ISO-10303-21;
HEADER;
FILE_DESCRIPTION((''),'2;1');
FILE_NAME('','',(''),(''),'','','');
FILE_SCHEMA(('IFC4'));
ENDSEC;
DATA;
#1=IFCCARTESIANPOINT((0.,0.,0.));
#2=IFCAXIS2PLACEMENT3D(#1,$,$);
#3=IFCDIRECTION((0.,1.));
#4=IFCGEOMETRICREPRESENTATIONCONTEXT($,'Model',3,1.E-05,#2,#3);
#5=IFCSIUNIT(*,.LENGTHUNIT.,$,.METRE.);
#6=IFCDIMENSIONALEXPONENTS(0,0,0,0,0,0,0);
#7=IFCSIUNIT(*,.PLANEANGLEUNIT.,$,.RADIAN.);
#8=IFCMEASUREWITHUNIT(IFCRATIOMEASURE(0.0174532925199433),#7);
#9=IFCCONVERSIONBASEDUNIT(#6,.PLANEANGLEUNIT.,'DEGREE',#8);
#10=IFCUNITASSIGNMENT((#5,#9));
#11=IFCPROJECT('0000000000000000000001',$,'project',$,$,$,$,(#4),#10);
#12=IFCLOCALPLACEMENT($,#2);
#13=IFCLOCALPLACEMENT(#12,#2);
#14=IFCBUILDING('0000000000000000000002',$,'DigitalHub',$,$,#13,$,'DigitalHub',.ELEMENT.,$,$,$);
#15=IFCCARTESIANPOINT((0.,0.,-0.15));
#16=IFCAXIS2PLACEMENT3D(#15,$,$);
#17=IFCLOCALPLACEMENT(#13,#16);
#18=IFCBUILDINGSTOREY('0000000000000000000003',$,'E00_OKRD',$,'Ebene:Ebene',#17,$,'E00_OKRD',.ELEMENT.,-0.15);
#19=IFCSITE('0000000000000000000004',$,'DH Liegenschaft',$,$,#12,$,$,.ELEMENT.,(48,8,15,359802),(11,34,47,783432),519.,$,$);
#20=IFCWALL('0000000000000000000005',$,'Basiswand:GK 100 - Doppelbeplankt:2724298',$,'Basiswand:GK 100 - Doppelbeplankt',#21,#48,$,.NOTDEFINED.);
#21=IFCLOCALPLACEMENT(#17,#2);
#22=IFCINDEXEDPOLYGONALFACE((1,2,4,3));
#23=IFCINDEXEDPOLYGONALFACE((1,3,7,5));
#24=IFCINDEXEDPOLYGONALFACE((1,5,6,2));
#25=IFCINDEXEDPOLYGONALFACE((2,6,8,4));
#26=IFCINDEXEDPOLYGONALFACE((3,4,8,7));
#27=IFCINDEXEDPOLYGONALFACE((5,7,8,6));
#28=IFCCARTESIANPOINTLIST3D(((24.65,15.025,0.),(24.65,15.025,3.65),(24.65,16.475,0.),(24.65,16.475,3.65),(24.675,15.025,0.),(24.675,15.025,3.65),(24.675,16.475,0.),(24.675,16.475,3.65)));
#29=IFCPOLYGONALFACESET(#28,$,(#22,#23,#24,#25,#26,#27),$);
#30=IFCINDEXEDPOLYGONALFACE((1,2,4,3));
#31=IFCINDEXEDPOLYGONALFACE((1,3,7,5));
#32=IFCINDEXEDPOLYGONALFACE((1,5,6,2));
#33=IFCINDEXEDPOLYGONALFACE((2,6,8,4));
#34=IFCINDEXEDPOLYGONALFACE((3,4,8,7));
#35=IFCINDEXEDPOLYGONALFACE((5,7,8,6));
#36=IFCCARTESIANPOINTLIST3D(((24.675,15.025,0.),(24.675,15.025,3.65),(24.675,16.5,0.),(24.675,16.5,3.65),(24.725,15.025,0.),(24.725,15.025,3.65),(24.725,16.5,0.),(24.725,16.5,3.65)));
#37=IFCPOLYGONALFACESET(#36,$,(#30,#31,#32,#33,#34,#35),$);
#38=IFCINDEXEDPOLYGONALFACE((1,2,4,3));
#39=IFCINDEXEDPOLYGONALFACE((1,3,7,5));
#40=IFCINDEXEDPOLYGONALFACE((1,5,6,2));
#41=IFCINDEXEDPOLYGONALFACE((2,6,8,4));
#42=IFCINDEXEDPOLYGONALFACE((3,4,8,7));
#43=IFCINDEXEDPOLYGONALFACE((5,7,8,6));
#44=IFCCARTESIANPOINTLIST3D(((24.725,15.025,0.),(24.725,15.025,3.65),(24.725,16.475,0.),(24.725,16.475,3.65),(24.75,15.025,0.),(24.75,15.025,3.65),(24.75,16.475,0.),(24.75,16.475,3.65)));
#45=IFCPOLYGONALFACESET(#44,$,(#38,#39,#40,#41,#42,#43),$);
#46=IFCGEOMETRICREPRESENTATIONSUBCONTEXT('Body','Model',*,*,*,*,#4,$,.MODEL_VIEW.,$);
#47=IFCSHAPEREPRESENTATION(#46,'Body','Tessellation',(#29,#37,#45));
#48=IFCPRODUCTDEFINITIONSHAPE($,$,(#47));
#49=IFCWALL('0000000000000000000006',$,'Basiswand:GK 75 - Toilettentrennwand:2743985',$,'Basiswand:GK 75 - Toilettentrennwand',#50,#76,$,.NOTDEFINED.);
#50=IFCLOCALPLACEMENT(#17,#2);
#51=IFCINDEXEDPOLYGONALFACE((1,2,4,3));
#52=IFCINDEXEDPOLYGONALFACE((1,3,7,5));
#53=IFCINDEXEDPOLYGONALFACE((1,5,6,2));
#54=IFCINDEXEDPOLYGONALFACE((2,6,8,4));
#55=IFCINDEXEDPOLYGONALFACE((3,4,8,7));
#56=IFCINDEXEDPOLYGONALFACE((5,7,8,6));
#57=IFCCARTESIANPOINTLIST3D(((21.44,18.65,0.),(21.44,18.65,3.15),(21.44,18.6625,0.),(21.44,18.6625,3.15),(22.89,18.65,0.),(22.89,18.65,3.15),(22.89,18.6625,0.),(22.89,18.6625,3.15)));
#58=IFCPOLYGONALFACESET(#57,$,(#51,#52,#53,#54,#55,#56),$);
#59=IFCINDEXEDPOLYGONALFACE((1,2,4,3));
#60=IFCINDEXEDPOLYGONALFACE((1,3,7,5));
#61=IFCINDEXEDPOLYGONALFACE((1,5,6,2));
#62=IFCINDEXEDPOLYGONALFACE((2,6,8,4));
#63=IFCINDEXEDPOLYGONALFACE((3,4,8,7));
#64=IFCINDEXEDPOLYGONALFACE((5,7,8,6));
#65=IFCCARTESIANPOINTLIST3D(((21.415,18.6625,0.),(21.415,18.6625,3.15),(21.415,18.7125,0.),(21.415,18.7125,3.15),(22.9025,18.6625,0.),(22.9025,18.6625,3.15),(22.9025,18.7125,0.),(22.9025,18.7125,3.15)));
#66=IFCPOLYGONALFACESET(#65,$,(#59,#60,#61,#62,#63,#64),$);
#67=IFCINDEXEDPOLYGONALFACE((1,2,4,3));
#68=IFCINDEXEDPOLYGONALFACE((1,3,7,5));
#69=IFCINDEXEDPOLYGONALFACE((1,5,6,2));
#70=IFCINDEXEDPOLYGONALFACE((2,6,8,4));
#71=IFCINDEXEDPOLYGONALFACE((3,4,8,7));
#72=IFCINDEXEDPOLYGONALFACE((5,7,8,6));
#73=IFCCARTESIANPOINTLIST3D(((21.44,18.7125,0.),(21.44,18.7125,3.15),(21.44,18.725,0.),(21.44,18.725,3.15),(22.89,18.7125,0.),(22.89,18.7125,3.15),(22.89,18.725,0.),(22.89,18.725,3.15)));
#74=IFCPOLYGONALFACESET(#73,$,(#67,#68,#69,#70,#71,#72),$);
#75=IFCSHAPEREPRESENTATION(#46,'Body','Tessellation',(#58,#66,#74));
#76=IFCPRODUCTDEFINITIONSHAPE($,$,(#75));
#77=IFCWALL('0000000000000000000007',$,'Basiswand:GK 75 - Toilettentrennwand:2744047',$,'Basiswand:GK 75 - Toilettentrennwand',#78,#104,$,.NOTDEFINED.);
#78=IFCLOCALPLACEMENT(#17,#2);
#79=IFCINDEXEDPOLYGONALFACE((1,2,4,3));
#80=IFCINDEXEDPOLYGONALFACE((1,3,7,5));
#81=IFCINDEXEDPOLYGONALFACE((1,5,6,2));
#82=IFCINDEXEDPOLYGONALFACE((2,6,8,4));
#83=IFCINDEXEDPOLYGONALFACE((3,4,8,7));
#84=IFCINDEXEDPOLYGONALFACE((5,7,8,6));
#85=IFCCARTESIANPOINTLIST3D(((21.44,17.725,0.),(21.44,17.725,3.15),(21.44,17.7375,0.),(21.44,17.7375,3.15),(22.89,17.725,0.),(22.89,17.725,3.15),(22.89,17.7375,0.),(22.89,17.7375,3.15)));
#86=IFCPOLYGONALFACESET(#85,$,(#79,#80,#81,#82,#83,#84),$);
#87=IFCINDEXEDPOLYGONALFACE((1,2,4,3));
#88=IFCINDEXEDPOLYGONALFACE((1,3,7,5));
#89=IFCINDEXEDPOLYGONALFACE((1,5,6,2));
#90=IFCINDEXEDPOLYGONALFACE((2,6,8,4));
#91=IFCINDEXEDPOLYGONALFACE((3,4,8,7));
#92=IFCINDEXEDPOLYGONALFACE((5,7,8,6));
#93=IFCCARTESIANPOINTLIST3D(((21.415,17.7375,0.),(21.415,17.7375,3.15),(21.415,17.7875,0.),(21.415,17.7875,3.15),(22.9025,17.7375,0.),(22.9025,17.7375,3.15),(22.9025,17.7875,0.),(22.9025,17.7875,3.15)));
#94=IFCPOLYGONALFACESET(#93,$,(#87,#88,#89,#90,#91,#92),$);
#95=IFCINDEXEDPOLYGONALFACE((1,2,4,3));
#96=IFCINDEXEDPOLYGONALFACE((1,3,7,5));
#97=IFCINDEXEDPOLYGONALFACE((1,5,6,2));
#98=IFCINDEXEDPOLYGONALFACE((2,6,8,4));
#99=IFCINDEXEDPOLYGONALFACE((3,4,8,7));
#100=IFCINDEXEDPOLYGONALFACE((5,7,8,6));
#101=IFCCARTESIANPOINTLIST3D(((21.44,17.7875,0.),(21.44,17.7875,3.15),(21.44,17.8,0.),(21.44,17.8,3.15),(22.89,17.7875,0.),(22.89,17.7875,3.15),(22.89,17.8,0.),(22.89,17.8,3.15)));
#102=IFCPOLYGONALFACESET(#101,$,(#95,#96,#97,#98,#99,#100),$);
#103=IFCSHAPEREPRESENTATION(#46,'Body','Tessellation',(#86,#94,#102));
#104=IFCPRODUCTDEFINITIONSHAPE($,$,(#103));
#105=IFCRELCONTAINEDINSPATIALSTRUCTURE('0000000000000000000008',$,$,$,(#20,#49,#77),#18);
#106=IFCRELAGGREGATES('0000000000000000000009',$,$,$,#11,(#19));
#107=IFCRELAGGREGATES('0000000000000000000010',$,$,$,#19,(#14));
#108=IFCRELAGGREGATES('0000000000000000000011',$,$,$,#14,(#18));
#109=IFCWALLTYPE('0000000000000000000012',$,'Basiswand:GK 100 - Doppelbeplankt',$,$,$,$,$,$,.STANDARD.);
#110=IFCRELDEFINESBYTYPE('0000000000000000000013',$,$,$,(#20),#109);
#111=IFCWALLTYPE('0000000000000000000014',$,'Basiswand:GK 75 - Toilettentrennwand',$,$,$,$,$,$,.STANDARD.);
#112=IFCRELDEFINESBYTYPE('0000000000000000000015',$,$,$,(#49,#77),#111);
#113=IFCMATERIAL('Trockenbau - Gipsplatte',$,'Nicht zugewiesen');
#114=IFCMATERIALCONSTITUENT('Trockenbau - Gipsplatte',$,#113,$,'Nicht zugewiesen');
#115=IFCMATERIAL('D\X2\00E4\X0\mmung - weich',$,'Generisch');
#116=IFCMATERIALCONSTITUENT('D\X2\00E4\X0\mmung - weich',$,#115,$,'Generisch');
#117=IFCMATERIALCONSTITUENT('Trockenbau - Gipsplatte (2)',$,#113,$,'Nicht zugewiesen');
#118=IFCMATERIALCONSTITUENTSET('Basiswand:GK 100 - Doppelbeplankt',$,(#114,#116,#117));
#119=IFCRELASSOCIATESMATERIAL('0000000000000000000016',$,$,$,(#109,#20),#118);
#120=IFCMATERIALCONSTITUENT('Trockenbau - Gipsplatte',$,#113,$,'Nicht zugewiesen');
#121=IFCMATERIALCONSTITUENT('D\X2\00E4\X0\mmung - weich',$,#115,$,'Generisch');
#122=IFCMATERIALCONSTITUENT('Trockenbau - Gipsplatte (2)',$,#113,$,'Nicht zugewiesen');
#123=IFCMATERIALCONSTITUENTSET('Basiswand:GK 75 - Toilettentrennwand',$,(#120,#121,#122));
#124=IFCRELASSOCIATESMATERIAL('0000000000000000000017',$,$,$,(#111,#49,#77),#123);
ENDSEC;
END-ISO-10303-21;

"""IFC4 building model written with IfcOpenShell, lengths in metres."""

from ifc_helpers import new_model, entity, si_unit, converted_unit, direction, frame, origin, place, context, subcontext, project, spatial, indexed_curve, outline, extrude, material, constituent, constituent_set, type_object, element, save


model = new_model("IFC4")

# Units and contexts
model_context = context("Model", 3, precision=1e-05, world=origin(), true_north=direction((0.0, 1.0)))
body_context = subcontext(model_context, "Body", "Model", "MODEL_VIEW")
ifc_project = project(units=[si_unit("LENGTHUNIT", "METRE"), converted_unit("PLANEANGLEUNIT", "DEGREE", entity("IfcRatioMeasure", 0.0174532925199433), si_unit("PLANEANGLEUNIT", "RADIAN"), dimensions=[0, 0, 0, 0, 0, 0, 0])], contexts=[model_context])

# Site, building, storey
site_placement = place(None, frame((0.0, 0.0, 0.0)))
site = spatial("IfcSite", under=ifc_project, at=site_placement, Name="DH Liegenschaft", CompositionType="ELEMENT", RefLatitude=(48, 8, 15, 359802), RefLongitude=(11, 34, 47, 783432), RefElevation=519.0)
building_placement = place(site_placement, origin())
building = spatial("IfcBuilding", under=site, at=building_placement, Name="DigitalHub", LongName="DigitalHub", CompositionType="ELEMENT")
storey_placement = place(building_placement, frame((0.0, 0.0, -0.15)))
storey = spatial("IfcBuildingStorey", under=building, at=storey_placement, Name="E00_OKRD", ObjectType="Ebene:Ebene", LongName="E00_OKRD", CompositionType="ELEMENT", Elevation=-0.15)

# Walls
ifc_material_1 = material(Name="Trockenbau - Gipsplatte", Category="Nicht zugewiesen")
ifc_material_2 = material(Name="Dämmung - weich", Category="Generisch")
ifc_constituent_1 = constituent(ifc_material_1, Name="Trockenbau - Gipsplatte", Category="Nicht zugewiesen")
ifc_constituent_2 = constituent(ifc_material_2, Name="Dämmung - weich", Category="Generisch")
ifc_constituent_3 = constituent(ifc_material_1, Name="Trockenbau - Gipsplatte (2)", Category="Nicht zugewiesen")
ifc_constituent_set_1 = constituent_set(constituents=[ifc_constituent_1, ifc_constituent_2, ifc_constituent_3], Name="Basiswand:GK 100 - Doppelbeplankt")
wall_type_1 = type_object("IfcWallType", Name="Basiswand:GK 100 - Doppelbeplankt", PredefinedType="STANDARD", material=ifc_constituent_set_1)
wall_1_placement = place(storey_placement, frame((24.7, 16.475, 0.0), z_axis=(0.0, 0.0, 1.0), x_axis=(0.0, -1.0, 0.0)))
element("IfcWall", 1, at=wall_1_placement, inside=storey, type_object=wall_type_1, material=ifc_constituent_set_1, Name="Basiswand:GK 100 - Doppelbeplankt:2724298", ObjectType="Basiswand:GK 100 - Doppelbeplankt", PredefinedType="NOTDEFINED", context=body_context, shape_type="SweptSolid", body=[
    extrude(outline(indexed_curve([(-0.0125, -0.725), (0.0125, -0.725), (0.0125, 0.725), (-0.0125, 0.725), (-0.0125, -0.725)], self_intersect=False)), frame((0.725, -0.0375, 0.0), z_axis=(0.0, 0.0, 1.0), x_axis=(0.0, 1.0, 0.0)), (0.0, 0.0, 1.0), 3.65),
    extrude(outline(indexed_curve([(-0.7375, -0.025), (0.7375, -0.025), (0.7375, 0.025), (-0.7375, 0.025), (-0.7375, -0.025)], self_intersect=False)), frame((0.7125, 0.0, 0.0)), (0.0, 0.0, 1.0), 3.65),
    extrude(outline(indexed_curve([(-0.0125, -0.725), (0.0125, -0.725), (0.0125, 0.725), (-0.0125, 0.725), (-0.0125, -0.725)], self_intersect=False)), frame((0.725, 0.0375, 0.0), z_axis=(0.0, 0.0, 1.0), x_axis=(0.0, -1.0, 0.0)), (0.0, 0.0, 1.0), 3.65),
])
ifc_constituent_4 = constituent(ifc_material_1, Name="Trockenbau - Gipsplatte", Category="Nicht zugewiesen")
ifc_constituent_5 = constituent(ifc_material_2, Name="Dämmung - weich", Category="Generisch")
ifc_constituent_6 = constituent(ifc_material_1, Name="Trockenbau - Gipsplatte (2)", Category="Nicht zugewiesen")
ifc_constituent_set_2 = constituent_set(constituents=[ifc_constituent_4, ifc_constituent_5, ifc_constituent_6], Name="Basiswand:GK 75 - Toilettentrennwand")
wall_type_2 = type_object("IfcWallType", Name="Basiswand:GK 75 - Toilettentrennwand", PredefinedType="STANDARD", material=ifc_constituent_set_2)
wall_2_placement = place(storey_placement, frame((21.44, 18.6875, 0.0)))
element("IfcWall", 2, at=wall_2_placement, inside=storey, type_object=wall_type_2, material=ifc_constituent_set_2, Name="Basiswand:GK 75 - Toilettentrennwand:2743985", ObjectType="Basiswand:GK 75 - Toilettentrennwand", PredefinedType="NOTDEFINED", context=body_context, shape_type="SweptSolid", body=[
    extrude(outline(indexed_curve([(-0.0063, -0.725), (0.0062, -0.725), (0.0063, 0.725), (-0.0062, 0.725), (-0.0063, -0.725)], self_intersect=False)), frame((0.725, -0.0313, 0.0), z_axis=(0.0, 0.0, 1.0), x_axis=(0.0, 1.0, 0.0)), (0.0, 0.0, 1.0), 3.15),
    extrude(outline(indexed_curve([(-0.7438, -0.025), (0.7438, -0.025), (0.7438, 0.025), (-0.7438, 0.025), (-0.7438, -0.025)], self_intersect=False)), frame((0.7187, 0.0, 0.0)), (0.0, 0.0, 1.0), 3.15),
    extrude(outline(indexed_curve([(-0.0063, -0.725), (0.0062, -0.725), (0.0063, 0.725), (-0.0062, 0.725), (-0.0063, -0.725)], self_intersect=False)), frame((0.725, 0.0312, 0.0), z_axis=(0.0, 0.0, 1.0), x_axis=(0.0, -1.0, 0.0)), (0.0, 0.0, 1.0), 3.15),
])
wall_3_placement = place(storey_placement, frame((21.44, 17.7625, 0.0)))
element("IfcWall", 3, at=wall_3_placement, inside=storey, type_object=wall_type_2, material=ifc_constituent_set_2, Name="Basiswand:GK 75 - Toilettentrennwand:2744047", ObjectType="Basiswand:GK 75 - Toilettentrennwand", PredefinedType="NOTDEFINED", context=body_context, shape_type="SweptSolid", body=[
    extrude(outline(indexed_curve([(-0.0063, -0.725), (0.0062, -0.725), (0.0063, 0.725), (-0.0062, 0.725), (-0.0063, -0.725)], self_intersect=False)), frame((0.725, -0.0313, 0.0), z_axis=(0.0, 0.0, 1.0), x_axis=(0.0, 1.0, 0.0)), (0.0, 0.0, 1.0), 3.15),
    extrude(outline(indexed_curve([(-0.7438, -0.025), (0.7438, -0.025), (0.7438, 0.025), (-0.7438, 0.025), (-0.7438, -0.025)], self_intersect=False)), frame((0.7188, 0.0, 0.0)), (0.0, 0.0, 1.0), 3.15),
    extrude(outline(indexed_curve([(-0.0063, -0.725), (0.0062, -0.725), (0.0063, 0.725), (-0.0062, 0.725), (-0.0063, -0.725)], self_intersect=False)), frame((0.725, 0.0312, 0.0), z_axis=(0.0, 0.0, 1.0), x_axis=(0.0, -1.0, 0.0)), (0.0, 0.0, 1.0), 3.15),
])

save(model, "model.ifc")
